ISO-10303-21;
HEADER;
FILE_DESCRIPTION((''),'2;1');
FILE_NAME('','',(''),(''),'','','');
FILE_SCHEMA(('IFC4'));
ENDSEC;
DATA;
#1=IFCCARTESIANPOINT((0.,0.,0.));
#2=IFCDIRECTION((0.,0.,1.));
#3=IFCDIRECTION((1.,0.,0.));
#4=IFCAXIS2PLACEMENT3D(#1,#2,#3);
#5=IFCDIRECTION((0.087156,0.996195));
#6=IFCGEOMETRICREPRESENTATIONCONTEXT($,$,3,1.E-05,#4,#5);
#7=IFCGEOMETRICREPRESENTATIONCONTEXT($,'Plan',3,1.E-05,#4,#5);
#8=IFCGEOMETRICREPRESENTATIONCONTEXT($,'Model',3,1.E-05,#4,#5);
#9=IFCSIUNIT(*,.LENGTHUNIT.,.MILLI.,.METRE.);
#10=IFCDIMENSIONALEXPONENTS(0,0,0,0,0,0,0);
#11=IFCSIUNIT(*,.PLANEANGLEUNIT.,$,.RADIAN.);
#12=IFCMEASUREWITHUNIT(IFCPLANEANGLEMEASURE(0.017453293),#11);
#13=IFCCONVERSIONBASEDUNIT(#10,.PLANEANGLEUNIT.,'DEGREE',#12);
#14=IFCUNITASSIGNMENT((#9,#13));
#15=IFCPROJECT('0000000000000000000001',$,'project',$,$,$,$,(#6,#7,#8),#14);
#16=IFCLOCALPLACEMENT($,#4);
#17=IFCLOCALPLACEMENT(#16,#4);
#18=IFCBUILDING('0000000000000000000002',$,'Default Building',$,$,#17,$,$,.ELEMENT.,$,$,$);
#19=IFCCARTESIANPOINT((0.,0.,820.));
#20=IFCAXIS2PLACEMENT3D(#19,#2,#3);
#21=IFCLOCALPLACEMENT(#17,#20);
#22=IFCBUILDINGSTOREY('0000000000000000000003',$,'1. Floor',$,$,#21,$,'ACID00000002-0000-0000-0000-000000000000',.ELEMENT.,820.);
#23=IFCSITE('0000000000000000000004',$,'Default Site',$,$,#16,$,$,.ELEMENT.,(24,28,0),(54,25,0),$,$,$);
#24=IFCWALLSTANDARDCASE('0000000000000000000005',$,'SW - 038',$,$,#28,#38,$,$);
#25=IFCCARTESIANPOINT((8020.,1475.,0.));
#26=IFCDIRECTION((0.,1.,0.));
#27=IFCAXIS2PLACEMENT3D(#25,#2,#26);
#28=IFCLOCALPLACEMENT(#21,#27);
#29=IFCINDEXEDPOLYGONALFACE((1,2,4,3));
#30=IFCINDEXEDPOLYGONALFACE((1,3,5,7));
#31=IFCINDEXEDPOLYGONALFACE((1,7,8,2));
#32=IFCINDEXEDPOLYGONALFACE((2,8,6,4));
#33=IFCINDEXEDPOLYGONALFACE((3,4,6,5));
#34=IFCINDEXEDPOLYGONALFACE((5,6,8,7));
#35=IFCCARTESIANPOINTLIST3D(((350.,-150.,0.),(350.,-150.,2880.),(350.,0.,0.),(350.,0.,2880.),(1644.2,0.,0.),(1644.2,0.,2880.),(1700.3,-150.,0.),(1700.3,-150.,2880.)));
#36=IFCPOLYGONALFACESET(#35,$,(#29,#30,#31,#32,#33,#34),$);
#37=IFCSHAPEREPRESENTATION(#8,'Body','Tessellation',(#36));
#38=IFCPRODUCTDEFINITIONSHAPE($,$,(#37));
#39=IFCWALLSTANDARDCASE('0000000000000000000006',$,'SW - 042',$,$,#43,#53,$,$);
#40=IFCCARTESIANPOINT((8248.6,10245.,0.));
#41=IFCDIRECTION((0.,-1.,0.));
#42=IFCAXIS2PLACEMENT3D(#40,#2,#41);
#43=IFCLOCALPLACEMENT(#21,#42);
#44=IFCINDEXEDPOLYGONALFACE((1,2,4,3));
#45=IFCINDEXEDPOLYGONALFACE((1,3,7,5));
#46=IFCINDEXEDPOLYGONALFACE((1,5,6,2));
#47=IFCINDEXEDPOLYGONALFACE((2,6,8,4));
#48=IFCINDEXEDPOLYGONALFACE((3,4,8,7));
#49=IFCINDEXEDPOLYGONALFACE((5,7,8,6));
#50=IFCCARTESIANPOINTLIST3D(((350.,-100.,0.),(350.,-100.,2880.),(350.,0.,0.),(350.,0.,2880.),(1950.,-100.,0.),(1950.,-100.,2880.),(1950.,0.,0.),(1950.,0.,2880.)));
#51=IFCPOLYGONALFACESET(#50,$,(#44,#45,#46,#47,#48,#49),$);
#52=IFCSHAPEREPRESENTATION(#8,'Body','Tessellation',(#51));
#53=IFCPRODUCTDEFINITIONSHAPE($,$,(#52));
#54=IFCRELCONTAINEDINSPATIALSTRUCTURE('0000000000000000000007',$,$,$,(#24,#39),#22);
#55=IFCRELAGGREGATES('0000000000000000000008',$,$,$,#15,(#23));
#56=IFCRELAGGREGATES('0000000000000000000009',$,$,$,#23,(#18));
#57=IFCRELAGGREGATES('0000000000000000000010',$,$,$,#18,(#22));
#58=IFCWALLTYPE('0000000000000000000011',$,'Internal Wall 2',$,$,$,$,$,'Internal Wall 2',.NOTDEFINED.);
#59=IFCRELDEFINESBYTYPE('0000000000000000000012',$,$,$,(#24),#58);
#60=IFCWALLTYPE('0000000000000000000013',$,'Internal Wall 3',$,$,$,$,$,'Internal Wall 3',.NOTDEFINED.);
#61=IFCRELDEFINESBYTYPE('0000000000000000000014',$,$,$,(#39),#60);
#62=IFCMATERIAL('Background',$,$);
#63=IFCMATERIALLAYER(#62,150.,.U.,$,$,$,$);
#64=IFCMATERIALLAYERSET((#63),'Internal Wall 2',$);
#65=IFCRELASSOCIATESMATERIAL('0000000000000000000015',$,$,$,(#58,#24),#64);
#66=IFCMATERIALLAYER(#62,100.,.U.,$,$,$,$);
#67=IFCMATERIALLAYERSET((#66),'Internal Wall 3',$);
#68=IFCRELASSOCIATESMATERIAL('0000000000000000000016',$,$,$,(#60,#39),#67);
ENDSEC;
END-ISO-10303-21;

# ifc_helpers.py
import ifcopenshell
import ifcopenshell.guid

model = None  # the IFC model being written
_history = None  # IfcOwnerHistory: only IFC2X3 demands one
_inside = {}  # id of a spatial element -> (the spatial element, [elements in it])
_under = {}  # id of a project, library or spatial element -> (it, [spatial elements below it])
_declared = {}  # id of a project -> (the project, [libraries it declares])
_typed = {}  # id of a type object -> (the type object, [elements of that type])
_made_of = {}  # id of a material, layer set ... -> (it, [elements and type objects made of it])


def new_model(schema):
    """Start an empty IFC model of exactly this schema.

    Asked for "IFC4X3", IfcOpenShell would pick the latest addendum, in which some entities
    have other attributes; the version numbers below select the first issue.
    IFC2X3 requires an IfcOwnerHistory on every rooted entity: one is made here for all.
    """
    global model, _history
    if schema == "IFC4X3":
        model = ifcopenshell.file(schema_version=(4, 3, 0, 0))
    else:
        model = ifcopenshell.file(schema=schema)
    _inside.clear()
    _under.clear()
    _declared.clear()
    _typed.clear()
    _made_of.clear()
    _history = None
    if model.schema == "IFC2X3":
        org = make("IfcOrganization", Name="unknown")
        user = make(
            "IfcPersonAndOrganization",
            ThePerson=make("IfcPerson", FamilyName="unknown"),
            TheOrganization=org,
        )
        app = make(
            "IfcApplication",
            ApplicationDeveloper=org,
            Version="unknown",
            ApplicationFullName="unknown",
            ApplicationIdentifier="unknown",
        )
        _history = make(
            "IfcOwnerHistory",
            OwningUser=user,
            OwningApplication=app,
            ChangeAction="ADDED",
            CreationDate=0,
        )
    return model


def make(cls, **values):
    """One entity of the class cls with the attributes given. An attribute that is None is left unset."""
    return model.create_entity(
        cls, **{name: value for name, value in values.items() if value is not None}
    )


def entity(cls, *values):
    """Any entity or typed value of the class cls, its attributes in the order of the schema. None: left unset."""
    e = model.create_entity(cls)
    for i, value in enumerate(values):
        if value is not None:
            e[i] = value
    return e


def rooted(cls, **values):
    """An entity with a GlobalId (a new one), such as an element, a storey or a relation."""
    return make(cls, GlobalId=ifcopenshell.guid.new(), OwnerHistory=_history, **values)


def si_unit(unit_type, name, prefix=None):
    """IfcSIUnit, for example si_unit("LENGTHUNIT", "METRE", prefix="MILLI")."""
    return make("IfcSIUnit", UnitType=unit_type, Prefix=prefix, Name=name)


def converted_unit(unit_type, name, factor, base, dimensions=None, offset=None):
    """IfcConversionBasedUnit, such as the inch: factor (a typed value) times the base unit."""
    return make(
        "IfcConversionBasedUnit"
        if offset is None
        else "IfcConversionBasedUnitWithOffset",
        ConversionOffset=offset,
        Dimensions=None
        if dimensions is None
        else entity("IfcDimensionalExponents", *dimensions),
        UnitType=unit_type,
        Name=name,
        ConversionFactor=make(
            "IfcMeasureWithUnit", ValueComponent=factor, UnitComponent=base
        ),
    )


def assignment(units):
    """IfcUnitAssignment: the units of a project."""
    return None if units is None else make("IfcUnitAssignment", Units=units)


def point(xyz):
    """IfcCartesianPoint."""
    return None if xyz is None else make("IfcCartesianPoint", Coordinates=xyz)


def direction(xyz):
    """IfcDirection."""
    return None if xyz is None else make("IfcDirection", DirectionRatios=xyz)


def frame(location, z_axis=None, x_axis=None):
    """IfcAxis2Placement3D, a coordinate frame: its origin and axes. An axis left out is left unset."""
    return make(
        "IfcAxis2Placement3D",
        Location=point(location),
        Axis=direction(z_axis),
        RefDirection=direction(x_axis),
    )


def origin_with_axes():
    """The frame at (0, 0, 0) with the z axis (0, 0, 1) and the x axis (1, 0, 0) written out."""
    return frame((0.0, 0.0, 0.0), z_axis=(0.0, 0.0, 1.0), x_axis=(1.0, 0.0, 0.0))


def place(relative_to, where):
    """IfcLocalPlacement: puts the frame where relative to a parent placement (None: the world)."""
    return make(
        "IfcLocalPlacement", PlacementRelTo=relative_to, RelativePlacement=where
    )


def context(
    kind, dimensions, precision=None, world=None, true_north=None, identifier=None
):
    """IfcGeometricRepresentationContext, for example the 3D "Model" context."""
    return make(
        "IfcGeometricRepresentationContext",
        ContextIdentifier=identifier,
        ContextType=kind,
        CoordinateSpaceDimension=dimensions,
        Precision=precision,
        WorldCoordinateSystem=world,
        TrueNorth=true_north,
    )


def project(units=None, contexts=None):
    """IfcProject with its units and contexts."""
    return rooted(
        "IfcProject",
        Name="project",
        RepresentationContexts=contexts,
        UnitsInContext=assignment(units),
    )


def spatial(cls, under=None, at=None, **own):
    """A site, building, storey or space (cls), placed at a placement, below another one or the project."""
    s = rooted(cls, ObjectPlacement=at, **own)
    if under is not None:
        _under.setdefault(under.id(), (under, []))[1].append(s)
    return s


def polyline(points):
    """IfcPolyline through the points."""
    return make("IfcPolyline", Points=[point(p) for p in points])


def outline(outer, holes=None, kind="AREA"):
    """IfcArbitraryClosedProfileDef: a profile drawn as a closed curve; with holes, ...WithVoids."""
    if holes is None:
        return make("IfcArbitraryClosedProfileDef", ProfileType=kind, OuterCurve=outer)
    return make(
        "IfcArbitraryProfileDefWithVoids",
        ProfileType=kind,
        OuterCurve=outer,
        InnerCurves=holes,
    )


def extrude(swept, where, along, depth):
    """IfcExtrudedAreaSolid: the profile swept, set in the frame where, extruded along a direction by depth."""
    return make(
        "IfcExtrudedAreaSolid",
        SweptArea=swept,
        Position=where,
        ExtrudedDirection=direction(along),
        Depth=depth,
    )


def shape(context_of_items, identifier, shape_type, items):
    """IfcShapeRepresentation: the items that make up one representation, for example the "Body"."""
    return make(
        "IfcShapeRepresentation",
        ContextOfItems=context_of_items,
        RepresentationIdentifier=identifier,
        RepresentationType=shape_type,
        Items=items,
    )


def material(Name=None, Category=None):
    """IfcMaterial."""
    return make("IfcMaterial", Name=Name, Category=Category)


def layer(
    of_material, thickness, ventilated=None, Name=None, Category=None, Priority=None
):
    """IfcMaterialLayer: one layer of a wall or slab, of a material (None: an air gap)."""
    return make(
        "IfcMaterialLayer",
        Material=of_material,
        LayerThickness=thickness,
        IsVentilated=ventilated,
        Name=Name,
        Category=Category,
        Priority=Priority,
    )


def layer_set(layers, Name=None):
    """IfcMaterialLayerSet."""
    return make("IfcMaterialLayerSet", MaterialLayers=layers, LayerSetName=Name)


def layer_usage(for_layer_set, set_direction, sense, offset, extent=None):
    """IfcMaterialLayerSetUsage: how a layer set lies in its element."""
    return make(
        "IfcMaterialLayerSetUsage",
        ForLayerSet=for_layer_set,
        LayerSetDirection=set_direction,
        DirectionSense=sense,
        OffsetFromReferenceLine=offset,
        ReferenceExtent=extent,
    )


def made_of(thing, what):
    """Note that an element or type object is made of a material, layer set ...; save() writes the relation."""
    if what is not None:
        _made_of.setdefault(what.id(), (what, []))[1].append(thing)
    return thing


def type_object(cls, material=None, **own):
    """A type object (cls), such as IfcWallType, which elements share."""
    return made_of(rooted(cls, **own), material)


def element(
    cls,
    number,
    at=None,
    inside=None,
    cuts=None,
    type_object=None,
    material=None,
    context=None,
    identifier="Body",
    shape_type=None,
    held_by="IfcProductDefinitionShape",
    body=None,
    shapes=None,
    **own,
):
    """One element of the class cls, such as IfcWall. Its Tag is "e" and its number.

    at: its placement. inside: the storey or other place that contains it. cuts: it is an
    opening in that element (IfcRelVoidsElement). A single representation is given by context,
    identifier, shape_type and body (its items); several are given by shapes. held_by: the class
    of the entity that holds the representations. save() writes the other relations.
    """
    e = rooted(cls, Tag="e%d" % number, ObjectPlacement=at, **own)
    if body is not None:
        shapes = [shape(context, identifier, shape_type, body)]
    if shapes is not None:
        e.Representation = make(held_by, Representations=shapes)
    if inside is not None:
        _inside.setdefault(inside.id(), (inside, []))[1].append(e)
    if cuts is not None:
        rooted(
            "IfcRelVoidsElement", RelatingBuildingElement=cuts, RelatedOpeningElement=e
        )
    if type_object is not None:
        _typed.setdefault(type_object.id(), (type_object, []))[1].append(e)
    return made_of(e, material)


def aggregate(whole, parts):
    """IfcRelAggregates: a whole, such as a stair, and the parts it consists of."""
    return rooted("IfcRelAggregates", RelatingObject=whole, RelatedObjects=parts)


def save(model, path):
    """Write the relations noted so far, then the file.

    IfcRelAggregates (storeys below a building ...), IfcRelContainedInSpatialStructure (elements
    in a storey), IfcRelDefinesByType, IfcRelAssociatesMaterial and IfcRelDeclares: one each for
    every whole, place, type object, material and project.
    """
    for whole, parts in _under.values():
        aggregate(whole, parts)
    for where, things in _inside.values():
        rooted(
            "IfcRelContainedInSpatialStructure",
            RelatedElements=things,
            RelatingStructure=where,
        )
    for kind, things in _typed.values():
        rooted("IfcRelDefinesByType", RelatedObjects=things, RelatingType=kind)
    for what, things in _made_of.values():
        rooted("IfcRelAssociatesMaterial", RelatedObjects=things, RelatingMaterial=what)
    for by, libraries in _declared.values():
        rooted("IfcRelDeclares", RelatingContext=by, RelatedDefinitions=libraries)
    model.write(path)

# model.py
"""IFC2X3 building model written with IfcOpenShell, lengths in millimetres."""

from ifc_helpers import new_model, entity, si_unit, converted_unit, direction, frame, origin_with_axes, place, context, project, spatial, polyline, outline, extrude, material, layer, layer_set, layer_usage, type_object, element, save


model = new_model("IFC2X3")

# Units and contexts
context_of_model = context(None, 3, precision=1e-05, world=origin_with_axes(), true_north=direction((0.087156, 0.996195)))
plan_context = context("Plan", 3, precision=1e-05, world=origin_with_axes(), true_north=direction((0.087156, 0.996195)))
model_context = context("Model", 3, precision=1e-05, world=origin_with_axes(), true_north=direction((0.087156, 0.996195)))
ifc_project = project(units=[si_unit("LENGTHUNIT", "METRE", prefix="MILLI"), converted_unit("PLANEANGLEUNIT", "DEGREE", entity("IfcPlaneAngleMeasure", 0.017453293), si_unit("PLANEANGLEUNIT", "RADIAN"), dimensions=[0, 0, 0, 0, 0, 0, 0])], contexts=[context_of_model, plan_context, model_context])

# Site, building, storey
site_placement = place(None, origin_with_axes())
site = spatial("IfcSite", under=ifc_project, at=site_placement, Name="Default Site", CompositionType="ELEMENT", RefLatitude=(24, 28, 0), RefLongitude=(54, 25, 0))
building_placement = place(site_placement, origin_with_axes())
building = spatial("IfcBuilding", under=site, at=building_placement, Name="Default Building", CompositionType="ELEMENT")
storey_placement = place(building_placement, frame((0.0, 0.0, 820.0), z_axis=(0.0, 0.0, 1.0), x_axis=(1.0, 0.0, 0.0)))
storey = spatial("IfcBuildingStorey", under=building, at=storey_placement, Name="1. Floor", LongName="ACID00000002-0000-0000-0000-000000000000", CompositionType="ELEMENT", Elevation=820.0)

# Shared definitions
ifc_material_1 = material(Name="Background")

# Shared definitions
ifc_layer_1 = layer(ifc_material_1, 150.0, ventilated="UNKNOWN")
ifc_layer_set_1 = layer_set([ifc_layer_1], Name="Internal Wall 2")
wall_type_1 = type_object("IfcWallType", Name="Internal Wall 2", ElementType="Internal Wall 2", PredefinedType="NOTDEFINED", material=ifc_layer_set_1)

# Walls
ifc_layer_usage_1 = layer_usage(ifc_layer_set_1, "AXIS2", "NEGATIVE", 0.0)
wall_1_placement = place(storey_placement, frame((8020.0, 1475.0, 0.0), z_axis=(0.0, 0.0, 1.0), x_axis=(0.0, 1.0, 0.0)))
element("IfcWallStandardCase", 1, at=wall_1_placement, inside=storey, type_object=wall_type_1, material=ifc_layer_usage_1, Name="SW - 038", context=model_context, shape_type="SweptSolid", body=[
    extrude(outline(polyline([(350.0, -150.0), (1700.3, -150.0), (1644.2, 0.0), (350.0, 0.0), (350.0, -150.0)])), origin_with_axes(), (0.0, 0.0, 1.0), 2880.0),
])
ifc_layer_2 = layer(ifc_material_1, 100.0, ventilated="UNKNOWN")
ifc_layer_set_2 = layer_set([ifc_layer_2], Name="Internal Wall 3")
ifc_layer_usage_2 = layer_usage(ifc_layer_set_2, "AXIS2", "NEGATIVE", 0.0)
wall_type_2 = type_object("IfcWallType", Name="Internal Wall 3", ElementType="Internal Wall 3", PredefinedType="NOTDEFINED", material=ifc_layer_set_2)
wall_2_placement = place(storey_placement, frame((8248.6, 10245.0, 0.0), z_axis=(0.0, 0.0, 1.0), x_axis=(0.0, -1.0, 0.0)))
element("IfcWallStandardCase", 2, at=wall_2_placement, inside=storey, type_object=wall_type_2, material=ifc_layer_usage_2, Name="SW - 042", context=model_context, shape_type="SweptSolid", body=[
    extrude(outline(polyline([(350.0, -100.0), (1950.0, -100.0), (1950.0, 0.0), (350.0, 0.0), (350.0, -100.0)])), origin_with_axes(), (0.0, 0.0, 1.0), 2880.0),
])

save(model, "model.ifc")
